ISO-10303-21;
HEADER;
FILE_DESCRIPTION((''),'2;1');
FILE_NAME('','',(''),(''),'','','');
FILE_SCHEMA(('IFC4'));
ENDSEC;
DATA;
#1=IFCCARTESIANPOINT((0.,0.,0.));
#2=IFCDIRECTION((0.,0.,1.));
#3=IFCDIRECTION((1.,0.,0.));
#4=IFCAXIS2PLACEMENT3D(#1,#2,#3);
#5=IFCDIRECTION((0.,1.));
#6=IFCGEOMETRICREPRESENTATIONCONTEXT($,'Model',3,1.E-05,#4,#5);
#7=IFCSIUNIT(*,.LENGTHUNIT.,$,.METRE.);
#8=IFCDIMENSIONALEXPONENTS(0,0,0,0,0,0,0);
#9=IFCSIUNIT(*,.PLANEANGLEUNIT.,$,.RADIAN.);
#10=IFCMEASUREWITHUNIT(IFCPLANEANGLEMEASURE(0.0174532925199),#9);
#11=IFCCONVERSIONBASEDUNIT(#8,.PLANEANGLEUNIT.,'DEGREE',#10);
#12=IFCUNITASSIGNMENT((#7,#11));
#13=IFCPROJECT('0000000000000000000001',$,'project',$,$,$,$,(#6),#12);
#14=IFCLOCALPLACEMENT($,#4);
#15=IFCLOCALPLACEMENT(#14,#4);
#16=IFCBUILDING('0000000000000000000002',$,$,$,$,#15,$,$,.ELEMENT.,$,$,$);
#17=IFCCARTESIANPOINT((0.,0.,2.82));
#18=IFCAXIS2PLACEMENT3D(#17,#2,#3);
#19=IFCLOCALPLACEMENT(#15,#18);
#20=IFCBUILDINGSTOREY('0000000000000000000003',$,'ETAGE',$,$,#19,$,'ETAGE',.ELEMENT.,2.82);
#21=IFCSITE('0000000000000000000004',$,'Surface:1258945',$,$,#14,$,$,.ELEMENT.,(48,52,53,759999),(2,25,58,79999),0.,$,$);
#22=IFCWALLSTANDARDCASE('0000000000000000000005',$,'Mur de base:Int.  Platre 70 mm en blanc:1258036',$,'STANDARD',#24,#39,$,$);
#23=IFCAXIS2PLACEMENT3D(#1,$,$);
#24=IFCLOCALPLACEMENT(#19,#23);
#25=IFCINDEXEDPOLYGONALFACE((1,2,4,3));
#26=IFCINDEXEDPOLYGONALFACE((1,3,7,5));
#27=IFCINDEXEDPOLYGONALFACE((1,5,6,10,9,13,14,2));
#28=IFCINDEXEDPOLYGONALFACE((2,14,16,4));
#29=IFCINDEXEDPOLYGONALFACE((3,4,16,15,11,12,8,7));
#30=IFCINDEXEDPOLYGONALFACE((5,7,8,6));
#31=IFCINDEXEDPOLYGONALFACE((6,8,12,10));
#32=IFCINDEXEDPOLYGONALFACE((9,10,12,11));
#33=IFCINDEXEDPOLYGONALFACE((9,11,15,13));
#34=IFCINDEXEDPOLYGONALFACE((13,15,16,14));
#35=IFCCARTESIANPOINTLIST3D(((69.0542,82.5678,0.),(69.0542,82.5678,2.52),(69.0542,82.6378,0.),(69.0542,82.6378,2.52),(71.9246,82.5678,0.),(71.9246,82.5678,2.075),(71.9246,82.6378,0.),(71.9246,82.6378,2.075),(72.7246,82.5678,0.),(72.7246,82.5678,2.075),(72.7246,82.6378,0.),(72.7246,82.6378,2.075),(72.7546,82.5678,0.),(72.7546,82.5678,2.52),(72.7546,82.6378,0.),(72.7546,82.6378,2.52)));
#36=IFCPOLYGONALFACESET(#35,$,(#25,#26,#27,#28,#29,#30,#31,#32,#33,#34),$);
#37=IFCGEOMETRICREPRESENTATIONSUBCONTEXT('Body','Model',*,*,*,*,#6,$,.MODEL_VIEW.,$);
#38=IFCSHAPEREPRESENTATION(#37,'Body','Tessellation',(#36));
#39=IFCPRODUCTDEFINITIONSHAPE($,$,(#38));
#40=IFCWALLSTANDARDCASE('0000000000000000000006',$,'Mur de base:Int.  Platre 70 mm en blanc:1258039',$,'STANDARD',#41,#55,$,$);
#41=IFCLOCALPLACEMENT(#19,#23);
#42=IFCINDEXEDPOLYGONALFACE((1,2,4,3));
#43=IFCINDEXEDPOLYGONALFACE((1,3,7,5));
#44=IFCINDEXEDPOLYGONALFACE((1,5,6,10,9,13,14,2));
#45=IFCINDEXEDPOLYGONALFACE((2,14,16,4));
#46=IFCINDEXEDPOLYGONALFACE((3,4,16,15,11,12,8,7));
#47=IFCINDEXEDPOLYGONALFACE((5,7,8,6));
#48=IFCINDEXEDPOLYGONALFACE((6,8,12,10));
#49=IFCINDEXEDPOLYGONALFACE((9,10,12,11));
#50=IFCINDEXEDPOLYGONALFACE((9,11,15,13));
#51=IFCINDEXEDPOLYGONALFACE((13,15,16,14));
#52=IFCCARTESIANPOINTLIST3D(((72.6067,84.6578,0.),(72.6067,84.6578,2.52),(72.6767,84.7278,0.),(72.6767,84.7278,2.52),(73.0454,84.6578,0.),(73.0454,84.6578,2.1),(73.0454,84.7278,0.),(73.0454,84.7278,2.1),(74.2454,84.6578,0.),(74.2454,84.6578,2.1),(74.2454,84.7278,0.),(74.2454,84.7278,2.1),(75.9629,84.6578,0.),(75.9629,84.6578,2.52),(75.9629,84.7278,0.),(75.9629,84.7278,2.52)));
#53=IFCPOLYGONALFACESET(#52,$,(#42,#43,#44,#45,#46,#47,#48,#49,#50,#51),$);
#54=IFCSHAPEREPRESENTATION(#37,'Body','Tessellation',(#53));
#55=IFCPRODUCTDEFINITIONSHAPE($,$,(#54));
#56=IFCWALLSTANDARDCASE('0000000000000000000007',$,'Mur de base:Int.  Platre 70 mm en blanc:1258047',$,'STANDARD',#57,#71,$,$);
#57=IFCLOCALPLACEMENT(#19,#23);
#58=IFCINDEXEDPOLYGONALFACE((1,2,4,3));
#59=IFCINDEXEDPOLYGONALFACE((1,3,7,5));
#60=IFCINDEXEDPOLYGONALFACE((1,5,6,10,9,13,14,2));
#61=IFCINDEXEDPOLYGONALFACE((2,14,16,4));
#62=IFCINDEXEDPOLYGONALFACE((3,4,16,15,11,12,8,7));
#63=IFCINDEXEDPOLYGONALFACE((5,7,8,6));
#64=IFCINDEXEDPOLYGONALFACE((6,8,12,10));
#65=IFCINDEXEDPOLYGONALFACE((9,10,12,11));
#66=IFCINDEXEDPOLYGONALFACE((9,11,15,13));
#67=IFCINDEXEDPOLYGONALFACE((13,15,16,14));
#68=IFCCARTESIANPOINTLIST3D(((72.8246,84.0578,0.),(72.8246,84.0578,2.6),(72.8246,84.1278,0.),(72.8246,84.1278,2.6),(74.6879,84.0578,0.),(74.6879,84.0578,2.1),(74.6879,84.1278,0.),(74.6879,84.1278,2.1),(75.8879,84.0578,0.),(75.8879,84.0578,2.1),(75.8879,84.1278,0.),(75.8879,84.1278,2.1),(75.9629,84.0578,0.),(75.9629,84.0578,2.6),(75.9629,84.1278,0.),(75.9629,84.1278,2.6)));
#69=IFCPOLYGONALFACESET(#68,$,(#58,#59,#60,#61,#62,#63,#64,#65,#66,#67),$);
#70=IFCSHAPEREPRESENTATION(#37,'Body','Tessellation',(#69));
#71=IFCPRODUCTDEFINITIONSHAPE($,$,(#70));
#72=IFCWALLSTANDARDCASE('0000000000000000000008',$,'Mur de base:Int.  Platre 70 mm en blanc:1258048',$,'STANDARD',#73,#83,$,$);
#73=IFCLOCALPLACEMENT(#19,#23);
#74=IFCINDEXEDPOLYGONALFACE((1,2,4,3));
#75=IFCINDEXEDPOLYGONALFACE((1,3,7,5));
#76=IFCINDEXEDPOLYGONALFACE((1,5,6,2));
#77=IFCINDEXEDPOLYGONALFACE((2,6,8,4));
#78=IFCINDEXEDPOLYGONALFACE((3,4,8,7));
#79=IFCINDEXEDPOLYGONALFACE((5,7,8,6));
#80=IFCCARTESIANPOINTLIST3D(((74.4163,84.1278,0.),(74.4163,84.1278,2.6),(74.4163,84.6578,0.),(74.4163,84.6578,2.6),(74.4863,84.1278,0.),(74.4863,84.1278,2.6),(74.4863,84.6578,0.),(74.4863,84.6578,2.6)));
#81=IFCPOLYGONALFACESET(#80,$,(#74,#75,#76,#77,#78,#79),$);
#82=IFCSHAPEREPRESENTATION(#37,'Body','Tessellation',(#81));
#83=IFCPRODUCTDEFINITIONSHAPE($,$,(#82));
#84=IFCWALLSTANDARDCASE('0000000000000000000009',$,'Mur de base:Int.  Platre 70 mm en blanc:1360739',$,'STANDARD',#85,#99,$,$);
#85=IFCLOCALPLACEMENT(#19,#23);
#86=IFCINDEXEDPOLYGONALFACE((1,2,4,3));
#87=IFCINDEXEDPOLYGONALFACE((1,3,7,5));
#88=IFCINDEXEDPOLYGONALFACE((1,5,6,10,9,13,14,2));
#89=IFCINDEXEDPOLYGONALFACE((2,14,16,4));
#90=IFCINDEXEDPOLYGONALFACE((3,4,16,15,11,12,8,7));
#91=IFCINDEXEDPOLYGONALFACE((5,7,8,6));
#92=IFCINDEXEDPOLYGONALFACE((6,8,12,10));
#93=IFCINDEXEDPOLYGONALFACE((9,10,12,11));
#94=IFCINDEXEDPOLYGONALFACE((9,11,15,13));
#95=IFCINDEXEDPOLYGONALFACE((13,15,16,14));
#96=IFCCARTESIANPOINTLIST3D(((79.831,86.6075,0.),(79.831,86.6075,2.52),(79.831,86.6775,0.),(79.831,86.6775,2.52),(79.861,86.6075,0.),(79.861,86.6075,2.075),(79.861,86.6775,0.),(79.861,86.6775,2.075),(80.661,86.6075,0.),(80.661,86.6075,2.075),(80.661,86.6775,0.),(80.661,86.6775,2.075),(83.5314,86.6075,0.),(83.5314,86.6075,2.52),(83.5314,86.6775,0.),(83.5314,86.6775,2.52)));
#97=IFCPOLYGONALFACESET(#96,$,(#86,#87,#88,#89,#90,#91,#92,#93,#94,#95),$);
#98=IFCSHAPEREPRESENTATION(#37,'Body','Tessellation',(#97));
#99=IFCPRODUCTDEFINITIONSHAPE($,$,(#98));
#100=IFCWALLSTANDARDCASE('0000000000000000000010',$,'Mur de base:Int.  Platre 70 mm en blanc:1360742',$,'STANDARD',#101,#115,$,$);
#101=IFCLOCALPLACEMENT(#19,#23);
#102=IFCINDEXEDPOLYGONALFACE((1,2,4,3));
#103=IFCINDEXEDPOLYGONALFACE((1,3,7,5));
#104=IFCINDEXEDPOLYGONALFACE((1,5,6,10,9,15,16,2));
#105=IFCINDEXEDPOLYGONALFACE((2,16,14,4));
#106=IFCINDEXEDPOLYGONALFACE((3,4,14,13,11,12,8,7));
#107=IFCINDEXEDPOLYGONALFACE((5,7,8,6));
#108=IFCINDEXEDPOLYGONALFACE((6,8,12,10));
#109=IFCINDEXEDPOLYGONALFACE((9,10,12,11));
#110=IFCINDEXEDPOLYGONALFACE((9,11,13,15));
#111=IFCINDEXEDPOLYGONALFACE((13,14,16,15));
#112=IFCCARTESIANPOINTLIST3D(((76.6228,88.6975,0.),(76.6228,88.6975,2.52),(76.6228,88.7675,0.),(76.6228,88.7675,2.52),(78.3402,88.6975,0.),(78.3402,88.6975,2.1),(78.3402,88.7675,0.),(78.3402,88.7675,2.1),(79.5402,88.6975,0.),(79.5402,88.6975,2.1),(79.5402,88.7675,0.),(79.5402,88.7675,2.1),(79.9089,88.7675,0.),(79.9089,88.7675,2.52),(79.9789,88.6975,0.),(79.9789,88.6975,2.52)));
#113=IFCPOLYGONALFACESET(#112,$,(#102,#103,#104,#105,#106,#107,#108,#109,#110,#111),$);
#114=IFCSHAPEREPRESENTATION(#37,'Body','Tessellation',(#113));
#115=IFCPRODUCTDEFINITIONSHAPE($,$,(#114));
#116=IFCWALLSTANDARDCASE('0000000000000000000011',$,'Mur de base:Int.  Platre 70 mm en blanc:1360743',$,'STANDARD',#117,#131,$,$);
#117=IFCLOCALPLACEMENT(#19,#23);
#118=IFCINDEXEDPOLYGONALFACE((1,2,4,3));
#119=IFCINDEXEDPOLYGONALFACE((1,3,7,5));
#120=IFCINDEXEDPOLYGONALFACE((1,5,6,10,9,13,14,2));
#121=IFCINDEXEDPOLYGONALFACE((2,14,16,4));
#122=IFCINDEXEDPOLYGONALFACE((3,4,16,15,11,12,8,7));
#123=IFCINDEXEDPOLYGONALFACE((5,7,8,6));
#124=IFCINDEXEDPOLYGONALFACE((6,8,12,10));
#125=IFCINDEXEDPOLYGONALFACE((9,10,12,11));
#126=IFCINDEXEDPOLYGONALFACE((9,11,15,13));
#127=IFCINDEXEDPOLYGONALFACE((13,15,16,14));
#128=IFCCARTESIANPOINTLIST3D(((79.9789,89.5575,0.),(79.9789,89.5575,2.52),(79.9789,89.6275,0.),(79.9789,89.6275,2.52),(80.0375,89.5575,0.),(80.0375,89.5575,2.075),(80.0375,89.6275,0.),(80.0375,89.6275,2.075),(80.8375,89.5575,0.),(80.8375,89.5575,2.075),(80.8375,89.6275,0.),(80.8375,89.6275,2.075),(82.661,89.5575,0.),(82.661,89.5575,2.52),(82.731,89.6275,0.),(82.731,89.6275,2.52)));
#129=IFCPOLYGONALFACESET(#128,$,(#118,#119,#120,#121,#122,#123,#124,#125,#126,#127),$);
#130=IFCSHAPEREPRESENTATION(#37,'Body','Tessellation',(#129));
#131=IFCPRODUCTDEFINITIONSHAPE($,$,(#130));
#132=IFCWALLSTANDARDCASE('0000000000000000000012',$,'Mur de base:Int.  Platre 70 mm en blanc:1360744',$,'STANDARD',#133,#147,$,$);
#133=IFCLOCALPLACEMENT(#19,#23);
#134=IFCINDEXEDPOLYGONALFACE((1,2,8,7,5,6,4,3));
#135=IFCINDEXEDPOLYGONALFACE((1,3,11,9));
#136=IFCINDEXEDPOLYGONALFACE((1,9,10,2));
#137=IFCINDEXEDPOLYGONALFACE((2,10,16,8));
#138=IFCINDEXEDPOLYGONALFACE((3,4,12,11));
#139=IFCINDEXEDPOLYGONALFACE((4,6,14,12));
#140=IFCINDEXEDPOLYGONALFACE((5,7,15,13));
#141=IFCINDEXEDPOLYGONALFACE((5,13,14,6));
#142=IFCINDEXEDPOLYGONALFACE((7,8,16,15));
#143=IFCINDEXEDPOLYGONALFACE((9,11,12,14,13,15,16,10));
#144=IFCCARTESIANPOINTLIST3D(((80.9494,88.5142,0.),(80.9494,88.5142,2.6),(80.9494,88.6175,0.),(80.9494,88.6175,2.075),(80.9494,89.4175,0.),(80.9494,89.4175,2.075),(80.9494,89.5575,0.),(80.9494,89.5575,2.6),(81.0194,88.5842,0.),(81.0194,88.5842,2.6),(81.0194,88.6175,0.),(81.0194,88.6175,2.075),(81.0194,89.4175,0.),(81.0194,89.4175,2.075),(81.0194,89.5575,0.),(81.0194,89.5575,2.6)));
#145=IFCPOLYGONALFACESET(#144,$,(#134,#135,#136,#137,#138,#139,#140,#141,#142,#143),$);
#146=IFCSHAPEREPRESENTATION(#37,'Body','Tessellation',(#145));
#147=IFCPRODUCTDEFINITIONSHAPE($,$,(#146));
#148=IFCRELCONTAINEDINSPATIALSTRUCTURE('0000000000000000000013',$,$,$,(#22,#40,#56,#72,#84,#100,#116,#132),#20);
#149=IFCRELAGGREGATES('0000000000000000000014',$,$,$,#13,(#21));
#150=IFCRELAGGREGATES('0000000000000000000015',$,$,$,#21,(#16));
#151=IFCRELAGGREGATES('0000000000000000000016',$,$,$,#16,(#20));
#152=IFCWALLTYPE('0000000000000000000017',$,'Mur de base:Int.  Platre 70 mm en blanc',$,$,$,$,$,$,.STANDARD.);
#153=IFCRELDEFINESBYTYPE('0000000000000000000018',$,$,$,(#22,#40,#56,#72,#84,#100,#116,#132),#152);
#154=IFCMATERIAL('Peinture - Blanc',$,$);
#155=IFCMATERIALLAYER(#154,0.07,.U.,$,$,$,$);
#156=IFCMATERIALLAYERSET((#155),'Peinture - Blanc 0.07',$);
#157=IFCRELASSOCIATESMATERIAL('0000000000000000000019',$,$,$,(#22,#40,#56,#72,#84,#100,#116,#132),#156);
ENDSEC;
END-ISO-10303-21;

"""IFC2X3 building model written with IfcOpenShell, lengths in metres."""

from ifc_helpers import new_model, entity, si_unit, converted_unit, direction, frame, origin_with_axes, place, context, subcontext, project, spatial, polyline, outline, extrude, material, layer, layer_set, layer_usage, type_object, element, save


model = new_model("IFC2X3")

# Units and contexts
model_context = context("Model", 3, precision=1e-05, world=origin_with_axes(), true_north=direction((0.0, 1.0)))
body_context = subcontext(model_context, "Body", "Model", "MODEL_VIEW")
ifc_project = project(units=[si_unit("LENGTHUNIT", "METRE"), converted_unit("PLANEANGLEUNIT", "DEGREE", entity("IfcPlaneAngleMeasure", 0.0174532925199), si_unit("PLANEANGLEUNIT", "RADIAN"), dimensions=[0, 0, 0, 0, 0, 0, 0])], contexts=[model_context])

# Site, building, storey
site_placement = place(None, origin_with_axes())
site = spatial("IfcSite", under=ifc_project, at=site_placement, Name="Surface:1258945", CompositionType="ELEMENT", RefLatitude=(48, 52, 53, 759999), RefLongitude=(2, 25, 58, 79999), RefElevation=0.0)
building_placement = place(site_placement, origin_with_axes())
building = spatial("IfcBuilding", under=site, at=building_placement, CompositionType="ELEMENT")
storey_placement = place(building_placement, frame((0.0, 0.0, 2.82), z_axis=(0.0, 0.0, 1.0), x_axis=(1.0, 0.0, 0.0)))
storey = spatial("IfcBuildingStorey", under=building, at=storey_placement, Name="ETAGE", LongName="ETAGE", CompositionType="ELEMENT", Elevation=2.82)

# Walls, openings
ifc_material_1 = material(Name="Peinture - Blanc")
ifc_layer_1 = layer(ifc_material_1, 0.07, ventilated="UNKNOWN")
ifc_layer_set_1 = layer_set([ifc_layer_1], Name="Peinture - Blanc 0.07")
wall_type_1 = type_object("IfcWallType", Name="Mur de base:Int.  Platre 70 mm en blanc", PredefinedType="STANDARD")
ifc_layer_usage_1 = layer_usage(ifc_layer_set_1, "AXIS2", "POSITIVE", -0.035)
wall_1_placement = place(storey_placement, frame((72.7896, 82.6028, 0.0), z_axis=(0.0, 0.0, 1.0), x_axis=(-1.0, 0.0, 0.0)))
wall_1 = element("IfcWallStandardCase", 1, at=wall_1_placement, inside=storey, type_object=wall_type_1, material=ifc_layer_usage_1, Name="Mur de base:Int.  Platre 70 mm en blanc:1258036", ObjectType="STANDARD", context=body_context, shape_type="SweptSolid", body=[
    extrude(outline(polyline([(0.035, -0.035), (3.7354, -0.035), (3.7354, 0.035), (0.035, 0.035), (0.035, -0.035)])), origin_with_axes(), (0.0, 0.0, 1.0), 2.52),
])
opening_1_placement = place(wall_1_placement, frame((0.465, 0.0, 0.0), z_axis=(0.0, 0.0, 1.0), x_axis=(1.0, 0.0, 0.0)))
element("IfcOpeningElement", 2, at=opening_1_placement, cuts=wall_1, context=body_context, shape_type="SweptSolid", body=[
    extrude(outline(polyline([(-0.4, 0.0), (0.4, 0.0), (0.4, 2.075), (-0.4, 2.075), (-0.4, 0.0)])), frame((0.0, -0.035, 0.0), z_axis=(0.0, -1.0, 0.0), x_axis=(1.0, 0.0, 0.0)), (0.0, 0.0, -1.0), 0.07),
])
ifc_layer_usage_2 = layer_usage(ifc_layer_set_1, "AXIS2", "POSITIVE", -0.035)
wall_2_placement = place(storey_placement, frame((72.6417, 84.6928, 0.0), z_axis=(0.0, 0.0, 1.0), x_axis=(1.0, 0.0, 0.0)))
wall_2 = element("IfcWallStandardCase", 3, at=wall_2_placement, inside=storey, type_object=wall_type_1, material=ifc_layer_usage_2, Name="Mur de base:Int.  Platre 70 mm en blanc:1258039", ObjectType="STANDARD", context=body_context, shape_type="SweptSolid", body=[
    extrude(outline(polyline([(-0.035, -0.035), (3.3211, -0.035), (3.3211, 0.035), (0.035, 0.035), (-0.035, -0.035)])), origin_with_axes(), (0.0, 0.0, 1.0), 2.52),
])
opening_2_placement = place(wall_2_placement, frame((1.0037, 0.0, 0.0), z_axis=(0.0, 0.0, 1.0), x_axis=(1.0, 0.0, 0.0)))
element("IfcOpeningElement", 4, at=opening_2_placement, cuts=wall_2, context=body_context, shape_type="SweptSolid", body=[
    extrude(outline(polyline([(0.6, 0.0), (0.6, 2.1), (-0.6, 2.1), (-0.6, 0.0), (0.6, 0.0)])), frame((0.0, -0.035, 0.0), z_axis=(0.0, 1.0, 0.0), x_axis=(-1.0, 0.0, 0.0)), (0.0, 0.0, 1.0), 0.07),
])
ifc_layer_usage_3 = layer_usage(ifc_layer_set_1, "AXIS2", "POSITIVE", -0.035)
wall_3_placement = place(storey_placement, frame((72.7896, 84.0928, 0.0), z_axis=(0.0, 0.0, 1.0), x_axis=(1.0, 0.0, 0.0)))
wall_3 = element("IfcWallStandardCase", 5, at=wall_3_placement, inside=storey, type_object=wall_type_1, material=ifc_layer_usage_3, Name="Mur de base:Int.  Platre 70 mm en blanc:1258047", ObjectType="STANDARD", context=body_context, shape_type="SweptSolid", body=[
    extrude(outline(polyline([(0.035, -0.035), (3.1733, -0.035), (3.1733, 0.035), (0.035, 0.035), (0.035, -0.035)])), origin_with_axes(), (0.0, 0.0, 1.0), 2.6),
])
opening_3_placement = place(wall_3_placement, frame((2.4983, 0.0, 0.0), z_axis=(0.0, 0.0, 1.0), x_axis=(1.0, 0.0, 0.0)))
element("IfcOpeningElement", 6, at=opening_3_placement, cuts=wall_3, context=body_context, shape_type="SweptSolid", body=[
    extrude(outline(polyline([(0.6, 0.0), (0.6, 2.1), (-0.6, 2.1), (-0.6, 0.0), (0.6, 0.0)])), frame((0.0, -0.035, 0.0), z_axis=(0.0, 1.0, 0.0), x_axis=(-1.0, 0.0, 0.0)), (0.0, 0.0, 1.0), 0.07),
])

# Wall
ifc_layer_usage_4 = layer_usage(ifc_layer_set_1, "AXIS2", "POSITIVE", -0.035)
wall_4_placement = place(storey_placement, frame((74.4513, 84.0928, 0.0), z_axis=(0.0, 0.0, 1.0), x_axis=(0.0, 1.0, 0.0)))
element("IfcWallStandardCase", 7, at=wall_4_placement, inside=storey, type_object=wall_type_1, material=ifc_layer_usage_4, Name="Mur de base:Int.  Platre 70 mm en blanc:1258048", ObjectType="STANDARD", context=body_context, shape_type="SweptSolid", body=[
    extrude(outline(polyline([(0.035, -0.035), (0.565, -0.035), (0.565, 0.035), (0.035, 0.035), (0.035, -0.035)])), origin_with_axes(), (0.0, 0.0, 1.0), 2.6),
])

# Walls, openings
ifc_layer_usage_5 = layer_usage(ifc_layer_set_1, "AXIS2", "POSITIVE", -0.035)
wall_5_placement = place(storey_placement, frame((79.796, 86.6425, 0.0), z_axis=(0.0, 0.0, 1.0), x_axis=(1.0, 0.0, 0.0)))
wall_5 = element("IfcWallStandardCase", 8, at=wall_5_placement, inside=storey, type_object=wall_type_1, material=ifc_layer_usage_5, Name="Mur de base:Int.  Platre 70 mm en blanc:1360739", ObjectType="STANDARD", context=body_context, shape_type="SweptSolid", body=[
    extrude(outline(polyline([(0.035, -0.035), (3.7354, -0.035), (3.7354, 0.035), (0.035, 0.035), (0.035, -0.035)])), origin_with_axes(), (0.0, 0.0, 1.0), 2.52),
])
opening_4_placement = place(wall_5_placement, frame((0.465, 0.0, 0.0), z_axis=(0.0, 0.0, 1.0), x_axis=(1.0, 0.0, 0.0)))
element("IfcOpeningElement", 9, at=opening_4_placement, cuts=wall_5, context=body_context, shape_type="SweptSolid", body=[
    extrude(outline(polyline([(0.4, 0.0), (0.4, 2.075), (-0.4, 2.075), (-0.4, 0.0), (0.4, 0.0)])), frame((0.0, 0.035, 0.0), z_axis=(0.0, -1.0, 0.0), x_axis=(1.0, 0.0, 0.0)), (0.0, 0.0, 1.0), 0.07),
])
ifc_layer_usage_6 = layer_usage(ifc_layer_set_1, "AXIS2", "POSITIVE", -0.035)
wall_6_placement = place(storey_placement, frame((79.9439, 88.7325, 0.0), z_axis=(0.0, 0.0, 1.0), x_axis=(-1.0, 0.0, 0.0)))
wall_6 = element("IfcWallStandardCase", 10, at=wall_6_placement, inside=storey, type_object=wall_type_1, material=ifc_layer_usage_6, Name="Mur de base:Int.  Platre 70 mm en blanc:1360742", ObjectType="STANDARD", context=body_context, shape_type="SweptSolid", body=[
    extrude(outline(polyline([(0.035, -0.035), (3.3211, -0.035), (3.3211, 0.035), (-0.035, 0.035), (0.035, -0.035)])), origin_with_axes(), (0.0, 0.0, 1.0), 2.52),
])
opening_5_placement = place(wall_6_placement, frame((1.0037, 0.0, 0.0), z_axis=(0.0, 0.0, 1.0), x_axis=(1.0, 0.0, 0.0)))
element("IfcOpeningElement", 11, at=opening_5_placement, cuts=wall_6, context=body_context, shape_type="SweptSolid", body=[
    extrude(outline(polyline([(0.6, 0.0), (0.6, 2.1), (-0.6, 2.1), (-0.6, 0.0), (0.6, 0.0)])), frame((0.0, 0.035, 0.0), z_axis=(0.0, -1.0, 0.0), x_axis=(1.0, 0.0, 0.0)), (0.0, 0.0, 1.0), 0.07),
])
ifc_layer_usage_7 = layer_usage(ifc_layer_set_1, "AXIS2", "POSITIVE", -0.035)
wall_7_placement = place(storey_placement, frame((82.696, 89.5925, 0.0), z_axis=(0.0, 0.0, 1.0), x_axis=(-1.0, 0.0, 0.0)))
wall_7 = element("IfcWallStandardCase", 12, at=wall_7_placement, inside=storey, type_object=wall_type_1, material=ifc_layer_usage_7, Name="Mur de base:Int.  Platre 70 mm en blanc:1360743", ObjectType="STANDARD", context=body_context, shape_type="SweptSolid", body=[
    extrude(outline(polyline([(-0.035, -0.035), (2.7171, -0.035), (2.7171, 0.035), (0.035, 0.035), (-0.035, -0.035)])), origin_with_axes(), (0.0, 0.0, 1.0), 2.52),
])
opening_6_placement = place(wall_7_placement, frame((2.2586, 0.0, 0.0), z_axis=(0.0, 0.0, 1.0), x_axis=(1.0, 0.0, 0.0)))
element("IfcOpeningElement", 13, at=opening_6_placement, cuts=wall_7, context=body_context, shape_type="SweptSolid", body=[
    extrude(outline(polyline([(-0.4, 0.0), (0.4, 0.0), (0.4, 2.075), (-0.4, 2.075), (-0.4, 0.0)])), frame((0.0, 0.035, 0.0), z_axis=(0.0, 1.0, 0.0), x_axis=(-1.0, 0.0, 0.0)), (0.0, 0.0, -1.0), 0.07),
])
ifc_layer_usage_8 = layer_usage(ifc_layer_set_1, "AXIS2", "POSITIVE", -0.035)
wall_8_placement = place(storey_placement, frame((80.9844, 88.5492, 0.0), z_axis=(0.0, 0.0, 1.0), x_axis=(0.0, 1.0, 0.0)))
wall_8 = element("IfcWallStandardCase", 14, at=wall_8_placement, inside=storey, type_object=wall_type_1, material=ifc_layer_usage_8, Name="Mur de base:Int.  Platre 70 mm en blanc:1360744", ObjectType="STANDARD", context=body_context, shape_type="SweptSolid", body=[
    extrude(outline(polyline([(0.035, -0.035), (1.0083, -0.035), (1.0083, 0.035), (-0.035, 0.035), (0.035, -0.035)])), origin_with_axes(), (0.0, 0.0, 1.0), 2.6),
])
opening_7_placement = place(wall_8_placement, frame((0.4683, 0.0, 0.0), z_axis=(0.0, 0.0, 1.0), x_axis=(1.0, 0.0, 0.0)))
element("IfcOpeningElement", 15, at=opening_7_placement, cuts=wall_8, context=body_context, shape_type="SweptSolid", body=[
    extrude(outline(polyline([(0.4, 0.0), (0.4, 2.075), (-0.4, 2.075), (-0.4, 0.0), (0.4, 0.0)])), frame((0.0, -0.035, 0.0), z_axis=(0.0, 1.0, 0.0), x_axis=(-1.0, 0.0, 0.0)), (0.0, 0.0, 1.0), 0.07),
])

save(model, "model.ifc")
